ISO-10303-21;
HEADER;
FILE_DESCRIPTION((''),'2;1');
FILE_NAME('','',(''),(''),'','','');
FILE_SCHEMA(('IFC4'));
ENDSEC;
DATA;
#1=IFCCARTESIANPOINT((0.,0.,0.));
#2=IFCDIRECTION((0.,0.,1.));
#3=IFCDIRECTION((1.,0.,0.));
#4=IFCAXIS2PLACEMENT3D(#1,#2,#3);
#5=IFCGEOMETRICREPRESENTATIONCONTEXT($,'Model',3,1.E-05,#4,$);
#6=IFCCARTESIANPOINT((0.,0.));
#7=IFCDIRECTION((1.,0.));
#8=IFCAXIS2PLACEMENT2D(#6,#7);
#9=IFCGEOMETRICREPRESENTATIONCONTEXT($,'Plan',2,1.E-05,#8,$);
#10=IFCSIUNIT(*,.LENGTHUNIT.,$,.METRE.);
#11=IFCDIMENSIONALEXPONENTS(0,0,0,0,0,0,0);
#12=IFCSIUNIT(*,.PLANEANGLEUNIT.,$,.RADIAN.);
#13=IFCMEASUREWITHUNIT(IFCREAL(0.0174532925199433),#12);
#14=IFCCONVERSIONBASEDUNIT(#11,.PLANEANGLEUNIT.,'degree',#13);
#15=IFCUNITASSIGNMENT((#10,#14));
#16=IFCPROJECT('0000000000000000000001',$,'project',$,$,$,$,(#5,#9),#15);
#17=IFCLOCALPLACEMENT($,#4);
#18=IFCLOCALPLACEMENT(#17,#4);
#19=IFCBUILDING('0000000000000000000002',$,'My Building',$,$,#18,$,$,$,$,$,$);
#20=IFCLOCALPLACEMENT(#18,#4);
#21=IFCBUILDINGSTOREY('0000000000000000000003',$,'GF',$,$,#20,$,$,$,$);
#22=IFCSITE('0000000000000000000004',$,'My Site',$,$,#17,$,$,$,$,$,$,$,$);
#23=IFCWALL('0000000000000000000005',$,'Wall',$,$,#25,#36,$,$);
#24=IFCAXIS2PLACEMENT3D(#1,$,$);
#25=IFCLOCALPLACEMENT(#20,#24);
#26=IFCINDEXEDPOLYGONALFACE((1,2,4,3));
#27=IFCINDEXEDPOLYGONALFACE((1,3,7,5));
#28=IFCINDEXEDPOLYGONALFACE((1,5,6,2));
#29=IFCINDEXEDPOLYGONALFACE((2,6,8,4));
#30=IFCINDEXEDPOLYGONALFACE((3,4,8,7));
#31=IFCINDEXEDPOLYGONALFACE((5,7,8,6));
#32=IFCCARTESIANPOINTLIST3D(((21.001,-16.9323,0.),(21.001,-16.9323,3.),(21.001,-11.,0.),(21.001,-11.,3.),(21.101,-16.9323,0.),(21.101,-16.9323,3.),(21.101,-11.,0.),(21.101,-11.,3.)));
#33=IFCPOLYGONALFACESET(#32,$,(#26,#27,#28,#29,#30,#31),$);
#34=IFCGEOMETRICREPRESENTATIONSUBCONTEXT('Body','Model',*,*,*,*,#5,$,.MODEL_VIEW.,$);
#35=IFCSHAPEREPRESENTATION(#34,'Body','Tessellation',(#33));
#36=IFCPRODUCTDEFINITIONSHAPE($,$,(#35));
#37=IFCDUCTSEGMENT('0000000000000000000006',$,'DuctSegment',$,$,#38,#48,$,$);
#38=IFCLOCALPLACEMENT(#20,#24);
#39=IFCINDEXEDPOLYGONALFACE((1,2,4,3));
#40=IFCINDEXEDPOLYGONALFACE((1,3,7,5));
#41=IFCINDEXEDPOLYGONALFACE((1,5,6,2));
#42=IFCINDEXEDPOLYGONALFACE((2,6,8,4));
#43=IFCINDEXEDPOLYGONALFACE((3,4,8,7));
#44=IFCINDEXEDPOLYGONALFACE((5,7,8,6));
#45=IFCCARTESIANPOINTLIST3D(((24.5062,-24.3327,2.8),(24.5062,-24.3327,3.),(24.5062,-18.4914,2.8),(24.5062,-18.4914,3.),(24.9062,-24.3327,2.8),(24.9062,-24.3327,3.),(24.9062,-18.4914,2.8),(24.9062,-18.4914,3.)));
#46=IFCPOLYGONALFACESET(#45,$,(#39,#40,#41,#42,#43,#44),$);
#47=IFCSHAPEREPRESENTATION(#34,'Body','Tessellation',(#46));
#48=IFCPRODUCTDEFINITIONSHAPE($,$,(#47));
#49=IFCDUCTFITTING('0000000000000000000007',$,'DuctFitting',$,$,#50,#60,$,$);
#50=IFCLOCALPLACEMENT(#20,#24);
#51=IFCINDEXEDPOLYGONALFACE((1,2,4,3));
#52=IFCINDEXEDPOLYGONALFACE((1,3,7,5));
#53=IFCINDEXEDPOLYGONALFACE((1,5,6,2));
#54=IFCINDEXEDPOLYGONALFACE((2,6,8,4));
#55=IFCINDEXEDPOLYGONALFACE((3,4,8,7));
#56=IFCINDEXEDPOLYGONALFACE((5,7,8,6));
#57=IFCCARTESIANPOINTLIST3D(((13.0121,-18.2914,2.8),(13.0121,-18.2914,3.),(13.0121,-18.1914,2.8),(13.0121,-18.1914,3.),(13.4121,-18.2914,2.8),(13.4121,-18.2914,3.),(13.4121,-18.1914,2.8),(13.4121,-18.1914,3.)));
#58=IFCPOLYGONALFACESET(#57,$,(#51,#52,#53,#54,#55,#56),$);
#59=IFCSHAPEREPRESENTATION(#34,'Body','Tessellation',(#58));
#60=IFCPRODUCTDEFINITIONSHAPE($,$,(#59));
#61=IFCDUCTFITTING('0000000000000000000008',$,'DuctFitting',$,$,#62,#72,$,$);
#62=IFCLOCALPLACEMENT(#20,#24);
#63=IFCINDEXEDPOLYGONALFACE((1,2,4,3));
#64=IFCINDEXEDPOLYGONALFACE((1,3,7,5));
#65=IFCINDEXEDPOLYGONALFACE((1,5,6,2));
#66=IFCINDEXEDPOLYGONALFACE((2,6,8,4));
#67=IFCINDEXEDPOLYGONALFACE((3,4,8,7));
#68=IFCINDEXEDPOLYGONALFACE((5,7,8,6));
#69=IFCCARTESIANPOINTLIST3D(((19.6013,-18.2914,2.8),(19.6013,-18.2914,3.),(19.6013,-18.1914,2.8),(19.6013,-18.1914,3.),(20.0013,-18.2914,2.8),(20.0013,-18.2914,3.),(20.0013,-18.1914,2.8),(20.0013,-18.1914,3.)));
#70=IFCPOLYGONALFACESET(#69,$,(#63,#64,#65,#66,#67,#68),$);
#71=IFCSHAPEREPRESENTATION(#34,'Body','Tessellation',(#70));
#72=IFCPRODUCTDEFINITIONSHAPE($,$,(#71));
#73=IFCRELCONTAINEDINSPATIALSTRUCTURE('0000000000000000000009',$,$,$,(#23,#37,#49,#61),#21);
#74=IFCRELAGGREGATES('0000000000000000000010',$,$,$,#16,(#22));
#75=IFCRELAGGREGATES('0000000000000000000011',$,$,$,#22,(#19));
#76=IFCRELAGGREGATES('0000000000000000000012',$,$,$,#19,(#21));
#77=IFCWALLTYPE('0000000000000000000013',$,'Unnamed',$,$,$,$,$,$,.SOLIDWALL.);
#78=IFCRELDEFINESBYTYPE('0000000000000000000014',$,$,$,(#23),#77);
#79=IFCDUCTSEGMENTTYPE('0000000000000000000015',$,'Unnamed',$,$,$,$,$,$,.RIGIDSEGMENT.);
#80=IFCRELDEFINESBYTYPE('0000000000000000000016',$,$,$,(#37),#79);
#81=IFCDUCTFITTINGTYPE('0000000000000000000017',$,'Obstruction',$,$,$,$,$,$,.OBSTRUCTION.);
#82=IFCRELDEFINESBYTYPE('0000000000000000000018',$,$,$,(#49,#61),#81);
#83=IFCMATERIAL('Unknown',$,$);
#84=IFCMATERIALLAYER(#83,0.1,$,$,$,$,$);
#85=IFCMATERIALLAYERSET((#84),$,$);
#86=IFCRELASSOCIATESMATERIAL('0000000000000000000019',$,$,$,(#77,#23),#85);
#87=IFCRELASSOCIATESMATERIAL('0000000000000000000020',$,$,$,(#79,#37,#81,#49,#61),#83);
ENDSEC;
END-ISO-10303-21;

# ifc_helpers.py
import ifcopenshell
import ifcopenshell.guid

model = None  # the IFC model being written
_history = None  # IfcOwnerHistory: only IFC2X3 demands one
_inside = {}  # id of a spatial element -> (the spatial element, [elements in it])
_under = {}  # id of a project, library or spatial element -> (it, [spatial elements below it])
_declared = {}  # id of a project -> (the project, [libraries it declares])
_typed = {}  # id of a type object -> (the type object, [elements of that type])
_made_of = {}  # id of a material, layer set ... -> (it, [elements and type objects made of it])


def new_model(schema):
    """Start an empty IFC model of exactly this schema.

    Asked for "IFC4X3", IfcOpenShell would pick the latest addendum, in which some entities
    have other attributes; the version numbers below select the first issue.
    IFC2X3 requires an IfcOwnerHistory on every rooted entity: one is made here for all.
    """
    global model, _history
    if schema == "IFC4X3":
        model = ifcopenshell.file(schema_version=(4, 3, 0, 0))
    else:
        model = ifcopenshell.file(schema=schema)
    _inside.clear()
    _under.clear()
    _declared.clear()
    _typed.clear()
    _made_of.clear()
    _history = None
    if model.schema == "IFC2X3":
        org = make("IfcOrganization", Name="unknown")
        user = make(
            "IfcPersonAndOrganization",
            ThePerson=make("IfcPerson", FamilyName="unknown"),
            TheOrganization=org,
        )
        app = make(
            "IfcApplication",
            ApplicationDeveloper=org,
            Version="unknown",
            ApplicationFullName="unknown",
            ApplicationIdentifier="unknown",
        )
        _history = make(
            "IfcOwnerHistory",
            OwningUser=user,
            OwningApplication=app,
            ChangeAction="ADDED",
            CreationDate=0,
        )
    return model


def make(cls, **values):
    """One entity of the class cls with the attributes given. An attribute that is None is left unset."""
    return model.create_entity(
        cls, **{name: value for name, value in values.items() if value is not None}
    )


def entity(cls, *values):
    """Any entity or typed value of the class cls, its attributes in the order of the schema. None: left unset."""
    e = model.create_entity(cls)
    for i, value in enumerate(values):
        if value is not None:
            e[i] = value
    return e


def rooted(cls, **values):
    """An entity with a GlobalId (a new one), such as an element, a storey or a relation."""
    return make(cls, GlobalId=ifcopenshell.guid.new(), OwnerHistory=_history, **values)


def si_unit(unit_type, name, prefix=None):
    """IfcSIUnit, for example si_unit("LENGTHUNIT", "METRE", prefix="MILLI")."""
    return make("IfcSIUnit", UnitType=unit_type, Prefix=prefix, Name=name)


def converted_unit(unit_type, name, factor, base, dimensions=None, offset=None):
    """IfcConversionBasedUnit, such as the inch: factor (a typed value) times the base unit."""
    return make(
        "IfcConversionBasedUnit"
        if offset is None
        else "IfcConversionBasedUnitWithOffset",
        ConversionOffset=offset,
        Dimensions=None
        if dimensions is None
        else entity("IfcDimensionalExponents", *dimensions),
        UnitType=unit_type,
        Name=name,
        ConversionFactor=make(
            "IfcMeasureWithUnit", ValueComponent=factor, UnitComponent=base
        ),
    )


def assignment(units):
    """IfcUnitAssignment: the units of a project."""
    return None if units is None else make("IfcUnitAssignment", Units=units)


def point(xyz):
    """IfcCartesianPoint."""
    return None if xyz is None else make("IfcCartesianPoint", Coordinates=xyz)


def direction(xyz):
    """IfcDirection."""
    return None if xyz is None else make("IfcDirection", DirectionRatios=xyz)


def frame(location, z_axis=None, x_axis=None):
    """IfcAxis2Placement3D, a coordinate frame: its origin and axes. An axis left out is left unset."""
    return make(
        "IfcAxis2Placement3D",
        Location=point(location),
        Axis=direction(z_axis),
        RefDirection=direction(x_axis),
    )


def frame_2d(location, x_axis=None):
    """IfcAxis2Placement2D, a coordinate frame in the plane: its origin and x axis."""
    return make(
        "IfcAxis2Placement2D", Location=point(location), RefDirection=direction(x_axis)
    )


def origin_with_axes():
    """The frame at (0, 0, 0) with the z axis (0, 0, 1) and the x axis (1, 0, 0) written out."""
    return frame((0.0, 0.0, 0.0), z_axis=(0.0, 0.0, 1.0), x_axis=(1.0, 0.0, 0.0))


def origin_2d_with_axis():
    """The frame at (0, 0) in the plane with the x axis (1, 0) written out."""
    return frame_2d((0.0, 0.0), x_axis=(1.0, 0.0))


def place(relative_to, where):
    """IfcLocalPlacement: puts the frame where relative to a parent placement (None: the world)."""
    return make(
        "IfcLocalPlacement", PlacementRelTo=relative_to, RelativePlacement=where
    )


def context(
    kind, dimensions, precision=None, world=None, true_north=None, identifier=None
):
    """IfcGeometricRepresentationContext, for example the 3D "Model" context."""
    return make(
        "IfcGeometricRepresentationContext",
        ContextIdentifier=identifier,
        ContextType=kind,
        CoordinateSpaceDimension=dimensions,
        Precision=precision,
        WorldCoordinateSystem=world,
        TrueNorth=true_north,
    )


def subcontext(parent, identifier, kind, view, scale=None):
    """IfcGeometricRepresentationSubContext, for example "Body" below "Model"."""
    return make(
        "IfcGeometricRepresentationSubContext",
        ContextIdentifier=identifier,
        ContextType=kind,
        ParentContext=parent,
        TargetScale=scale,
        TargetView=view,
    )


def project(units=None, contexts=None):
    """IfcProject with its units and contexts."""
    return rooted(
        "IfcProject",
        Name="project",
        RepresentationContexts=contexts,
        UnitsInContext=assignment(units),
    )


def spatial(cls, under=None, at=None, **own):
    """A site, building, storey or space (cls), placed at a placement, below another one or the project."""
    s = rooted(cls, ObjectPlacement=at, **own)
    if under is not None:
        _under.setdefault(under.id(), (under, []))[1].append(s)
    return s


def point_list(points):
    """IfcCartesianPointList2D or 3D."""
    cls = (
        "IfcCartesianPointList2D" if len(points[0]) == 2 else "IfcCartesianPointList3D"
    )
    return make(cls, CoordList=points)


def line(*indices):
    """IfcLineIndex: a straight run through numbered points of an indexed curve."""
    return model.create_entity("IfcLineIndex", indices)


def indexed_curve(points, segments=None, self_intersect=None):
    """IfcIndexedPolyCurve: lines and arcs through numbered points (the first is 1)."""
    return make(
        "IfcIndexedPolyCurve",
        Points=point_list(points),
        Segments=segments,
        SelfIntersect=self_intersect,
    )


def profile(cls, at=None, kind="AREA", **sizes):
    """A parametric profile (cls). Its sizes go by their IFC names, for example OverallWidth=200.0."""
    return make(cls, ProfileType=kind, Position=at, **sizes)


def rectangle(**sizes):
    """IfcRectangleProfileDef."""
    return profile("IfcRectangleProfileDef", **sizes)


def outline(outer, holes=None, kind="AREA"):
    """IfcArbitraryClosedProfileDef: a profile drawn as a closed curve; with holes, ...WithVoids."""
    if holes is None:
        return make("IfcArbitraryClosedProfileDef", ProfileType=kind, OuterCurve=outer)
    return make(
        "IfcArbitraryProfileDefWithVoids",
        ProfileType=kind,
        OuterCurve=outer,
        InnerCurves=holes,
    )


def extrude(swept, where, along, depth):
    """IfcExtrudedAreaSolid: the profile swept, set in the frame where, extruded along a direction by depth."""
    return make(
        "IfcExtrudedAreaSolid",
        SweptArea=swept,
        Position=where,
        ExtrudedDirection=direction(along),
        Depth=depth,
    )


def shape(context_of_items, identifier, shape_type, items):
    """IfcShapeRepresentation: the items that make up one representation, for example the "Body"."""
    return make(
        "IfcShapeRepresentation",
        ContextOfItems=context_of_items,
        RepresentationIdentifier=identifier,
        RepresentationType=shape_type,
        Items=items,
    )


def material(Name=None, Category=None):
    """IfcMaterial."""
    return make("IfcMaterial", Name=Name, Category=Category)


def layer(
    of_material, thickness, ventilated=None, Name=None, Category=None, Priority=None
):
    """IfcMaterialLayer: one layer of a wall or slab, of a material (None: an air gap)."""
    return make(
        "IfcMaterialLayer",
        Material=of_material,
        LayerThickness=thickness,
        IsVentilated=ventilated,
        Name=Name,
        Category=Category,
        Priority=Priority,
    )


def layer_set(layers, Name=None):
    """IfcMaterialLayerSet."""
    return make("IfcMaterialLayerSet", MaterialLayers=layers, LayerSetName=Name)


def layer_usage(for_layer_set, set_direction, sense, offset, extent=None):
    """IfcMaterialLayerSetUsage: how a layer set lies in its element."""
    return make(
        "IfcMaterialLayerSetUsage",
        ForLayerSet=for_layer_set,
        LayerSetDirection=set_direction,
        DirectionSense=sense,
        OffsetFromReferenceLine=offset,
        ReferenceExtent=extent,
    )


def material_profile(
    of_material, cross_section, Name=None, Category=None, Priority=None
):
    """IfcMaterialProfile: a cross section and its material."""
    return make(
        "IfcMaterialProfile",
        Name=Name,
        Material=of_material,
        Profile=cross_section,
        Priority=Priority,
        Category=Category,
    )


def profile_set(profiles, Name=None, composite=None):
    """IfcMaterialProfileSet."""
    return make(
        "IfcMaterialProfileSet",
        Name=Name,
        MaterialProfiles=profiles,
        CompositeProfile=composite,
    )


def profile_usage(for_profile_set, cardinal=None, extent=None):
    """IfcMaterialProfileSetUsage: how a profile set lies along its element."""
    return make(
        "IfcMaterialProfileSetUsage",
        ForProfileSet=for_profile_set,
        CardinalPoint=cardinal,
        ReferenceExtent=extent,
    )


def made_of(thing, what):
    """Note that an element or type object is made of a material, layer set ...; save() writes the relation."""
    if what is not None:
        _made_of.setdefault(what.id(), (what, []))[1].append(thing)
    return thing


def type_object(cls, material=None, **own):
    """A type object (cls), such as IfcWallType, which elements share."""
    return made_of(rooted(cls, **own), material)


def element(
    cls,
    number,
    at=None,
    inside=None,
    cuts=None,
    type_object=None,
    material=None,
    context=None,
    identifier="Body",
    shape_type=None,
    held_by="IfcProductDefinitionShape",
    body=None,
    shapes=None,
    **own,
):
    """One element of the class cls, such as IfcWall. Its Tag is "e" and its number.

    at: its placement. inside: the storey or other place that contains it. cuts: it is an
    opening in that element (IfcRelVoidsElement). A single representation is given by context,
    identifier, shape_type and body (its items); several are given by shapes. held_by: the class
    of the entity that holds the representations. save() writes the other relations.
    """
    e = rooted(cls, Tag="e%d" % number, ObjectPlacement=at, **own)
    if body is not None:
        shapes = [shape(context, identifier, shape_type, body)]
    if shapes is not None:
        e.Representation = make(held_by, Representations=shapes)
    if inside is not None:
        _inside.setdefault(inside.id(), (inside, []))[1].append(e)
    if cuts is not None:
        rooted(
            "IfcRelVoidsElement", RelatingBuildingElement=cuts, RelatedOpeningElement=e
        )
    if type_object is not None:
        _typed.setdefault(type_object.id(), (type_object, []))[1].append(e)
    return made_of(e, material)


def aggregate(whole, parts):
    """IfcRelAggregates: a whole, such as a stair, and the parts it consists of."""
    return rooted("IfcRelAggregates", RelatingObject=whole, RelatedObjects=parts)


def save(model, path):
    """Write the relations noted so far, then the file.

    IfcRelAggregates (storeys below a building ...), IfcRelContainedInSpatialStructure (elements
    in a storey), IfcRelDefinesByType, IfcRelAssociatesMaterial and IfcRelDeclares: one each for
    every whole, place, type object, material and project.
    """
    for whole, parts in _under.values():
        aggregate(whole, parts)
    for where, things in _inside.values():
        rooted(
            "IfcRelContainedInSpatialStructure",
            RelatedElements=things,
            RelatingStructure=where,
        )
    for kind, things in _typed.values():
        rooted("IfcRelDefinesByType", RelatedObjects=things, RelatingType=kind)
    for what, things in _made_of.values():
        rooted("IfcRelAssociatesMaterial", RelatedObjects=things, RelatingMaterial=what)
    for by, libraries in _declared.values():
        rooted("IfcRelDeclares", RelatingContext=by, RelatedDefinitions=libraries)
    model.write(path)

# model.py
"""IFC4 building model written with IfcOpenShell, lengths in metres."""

from ifc_helpers import new_model, entity, si_unit, converted_unit, frame, origin_with_axes, origin_2d_with_axis, place, context, subcontext, project, spatial, line, indexed_curve, rectangle, outline, extrude, material, layer, layer_set, layer_usage, material_profile, profile_set, profile_usage, type_object, element, save


model = new_model("IFC4")

# Units and contexts
model_context = context("Model", 3, precision=1e-05, world=origin_with_axes())
plan_context = context("Plan", 2, precision=1e-05, world=origin_2d_with_axis())
body_context_1 = subcontext(model_context, "Body", "Model", "MODEL_VIEW")
ifc_project = project(units=[si_unit("LENGTHUNIT", "METRE"), converted_unit("PLANEANGLEUNIT", "degree", entity("IfcReal", 0.0174532925199433), si_unit("PLANEANGLEUNIT", "RADIAN"), dimensions=[0, 0, 0, 0, 0, 0, 0])], contexts=[model_context, plan_context])

# Site, building, storey
site_placement = place(None, origin_with_axes())
site = spatial("IfcSite", under=ifc_project, at=site_placement, Name="My Site")
building_placement = place(site_placement, origin_with_axes())
building = spatial("IfcBuilding", under=site, at=building_placement, Name="My Building")
storey_placement = place(building_placement, origin_with_axes())
storey = spatial("IfcBuildingStorey", under=building, at=storey_placement, Name="GF")

# Shared definitions
ifc_material = material(Name="Unknown")
ifc_layer = layer(ifc_material, 0.1)
ifc_layer_set = layer_set([ifc_layer])
wall_type = type_object("IfcWallType", Name="Unnamed", PredefinedType="SOLIDWALL", material=ifc_layer_set)

# Wall
ifc_layer_usage_1 = layer_usage(ifc_layer_set, "AXIS2", "POSITIVE", 0.0)
wall_1_placement = place(storey_placement, frame((21.101, -16.9323, 0.0), z_axis=(0.0, 0.0, 1.0), x_axis=(0.0, 1.0, 0.0)))
element("IfcWall", 1, at=wall_1_placement, inside=storey, type_object=wall_type, material=ifc_layer_usage_1, Name="Wall", context=body_context_1, shape_type="SweptSolid", body=[
    extrude(outline(indexed_curve([(0.0, 0.0), (0.0, 0.1), (5.9323, 0.1), (5.9323, 0.0)], segments=[line(1, 2, 3, 4, 1)])), origin_with_axes(), (0.0, 0.0, 1.0), 3.0),
])

# Duct segment
ifc_material_profile_1 = material_profile(ifc_material, rectangle(XDim=0.4, YDim=0.2))
ifc_profile_set_1 = profile_set([ifc_material_profile_1])
ifc_profile_usage_1 = profile_usage(ifc_profile_set_1, cardinal=5)
duct_segment_type = type_object("IfcDuctSegmentType", Name="Unnamed", PredefinedType="RIGIDSEGMENT", material=ifc_profile_set_1)
duct_segment_placement = place(storey_placement, frame((24.7062, -18.4914, 2.9), z_axis=(0.0, -1.0, 0.0), x_axis=(1.0, 0.0, 0.0)))
element("IfcDuctSegment", 2, at=duct_segment_placement, inside=storey, type_object=duct_segment_type, material=ifc_profile_usage_1, Name="DuctSegment", context=body_context_1, shape_type="SweptSolid", body=[
    extrude(rectangle(XDim=0.4, YDim=0.2), origin_with_axes(), (0.0, 0.0, 1.0), 5.8413),
])

# Duct fittings
ifc_material_profile_2 = material_profile(ifc_material, rectangle(XDim=0.4, YDim=0.2))
ifc_profile_set_2 = profile_set([ifc_material_profile_2])
ifc_profile_usage_2 = profile_usage(ifc_profile_set_2, cardinal=5)
duct_fitting_type = type_object("IfcDuctFittingType", Name="Obstruction", PredefinedType="OBSTRUCTION", material=ifc_profile_set_2)
duct_fitting_1_placement = place(storey_placement, frame((13.2121, -18.1914, 2.9), z_axis=(0.0, -1.0, 0.0), x_axis=(1.0, 0.0, 0.0)))
element("IfcDuctFitting", 3, at=duct_fitting_1_placement, inside=storey, type_object=duct_fitting_type, material=ifc_profile_usage_2, Name="DuctFitting", context=body_context_1, shape_type="SweptSolid", body=[
    extrude(rectangle(XDim=0.4, YDim=0.2), origin_with_axes(), (0.0, 0.0, 1.0), 0.1),
])
ifc_profile_usage_3 = profile_usage(ifc_profile_set_2, cardinal=5)
duct_fitting_2_placement = place(storey_placement, frame((19.8013, -18.1914, 2.9), z_axis=(0.0, -1.0, 0.0), x_axis=(1.0, 0.0, 0.0)))
element("IfcDuctFitting", 4, at=duct_fitting_2_placement, inside=storey, type_object=duct_fitting_type, material=ifc_profile_usage_3, Name="DuctFitting", context=body_context_1, shape_type="SweptSolid", body=[
    extrude(rectangle(XDim=0.4, YDim=0.2), origin_with_axes(), (0.0, 0.0, 1.0), 0.1),
])

save(model, "model.ifc")
